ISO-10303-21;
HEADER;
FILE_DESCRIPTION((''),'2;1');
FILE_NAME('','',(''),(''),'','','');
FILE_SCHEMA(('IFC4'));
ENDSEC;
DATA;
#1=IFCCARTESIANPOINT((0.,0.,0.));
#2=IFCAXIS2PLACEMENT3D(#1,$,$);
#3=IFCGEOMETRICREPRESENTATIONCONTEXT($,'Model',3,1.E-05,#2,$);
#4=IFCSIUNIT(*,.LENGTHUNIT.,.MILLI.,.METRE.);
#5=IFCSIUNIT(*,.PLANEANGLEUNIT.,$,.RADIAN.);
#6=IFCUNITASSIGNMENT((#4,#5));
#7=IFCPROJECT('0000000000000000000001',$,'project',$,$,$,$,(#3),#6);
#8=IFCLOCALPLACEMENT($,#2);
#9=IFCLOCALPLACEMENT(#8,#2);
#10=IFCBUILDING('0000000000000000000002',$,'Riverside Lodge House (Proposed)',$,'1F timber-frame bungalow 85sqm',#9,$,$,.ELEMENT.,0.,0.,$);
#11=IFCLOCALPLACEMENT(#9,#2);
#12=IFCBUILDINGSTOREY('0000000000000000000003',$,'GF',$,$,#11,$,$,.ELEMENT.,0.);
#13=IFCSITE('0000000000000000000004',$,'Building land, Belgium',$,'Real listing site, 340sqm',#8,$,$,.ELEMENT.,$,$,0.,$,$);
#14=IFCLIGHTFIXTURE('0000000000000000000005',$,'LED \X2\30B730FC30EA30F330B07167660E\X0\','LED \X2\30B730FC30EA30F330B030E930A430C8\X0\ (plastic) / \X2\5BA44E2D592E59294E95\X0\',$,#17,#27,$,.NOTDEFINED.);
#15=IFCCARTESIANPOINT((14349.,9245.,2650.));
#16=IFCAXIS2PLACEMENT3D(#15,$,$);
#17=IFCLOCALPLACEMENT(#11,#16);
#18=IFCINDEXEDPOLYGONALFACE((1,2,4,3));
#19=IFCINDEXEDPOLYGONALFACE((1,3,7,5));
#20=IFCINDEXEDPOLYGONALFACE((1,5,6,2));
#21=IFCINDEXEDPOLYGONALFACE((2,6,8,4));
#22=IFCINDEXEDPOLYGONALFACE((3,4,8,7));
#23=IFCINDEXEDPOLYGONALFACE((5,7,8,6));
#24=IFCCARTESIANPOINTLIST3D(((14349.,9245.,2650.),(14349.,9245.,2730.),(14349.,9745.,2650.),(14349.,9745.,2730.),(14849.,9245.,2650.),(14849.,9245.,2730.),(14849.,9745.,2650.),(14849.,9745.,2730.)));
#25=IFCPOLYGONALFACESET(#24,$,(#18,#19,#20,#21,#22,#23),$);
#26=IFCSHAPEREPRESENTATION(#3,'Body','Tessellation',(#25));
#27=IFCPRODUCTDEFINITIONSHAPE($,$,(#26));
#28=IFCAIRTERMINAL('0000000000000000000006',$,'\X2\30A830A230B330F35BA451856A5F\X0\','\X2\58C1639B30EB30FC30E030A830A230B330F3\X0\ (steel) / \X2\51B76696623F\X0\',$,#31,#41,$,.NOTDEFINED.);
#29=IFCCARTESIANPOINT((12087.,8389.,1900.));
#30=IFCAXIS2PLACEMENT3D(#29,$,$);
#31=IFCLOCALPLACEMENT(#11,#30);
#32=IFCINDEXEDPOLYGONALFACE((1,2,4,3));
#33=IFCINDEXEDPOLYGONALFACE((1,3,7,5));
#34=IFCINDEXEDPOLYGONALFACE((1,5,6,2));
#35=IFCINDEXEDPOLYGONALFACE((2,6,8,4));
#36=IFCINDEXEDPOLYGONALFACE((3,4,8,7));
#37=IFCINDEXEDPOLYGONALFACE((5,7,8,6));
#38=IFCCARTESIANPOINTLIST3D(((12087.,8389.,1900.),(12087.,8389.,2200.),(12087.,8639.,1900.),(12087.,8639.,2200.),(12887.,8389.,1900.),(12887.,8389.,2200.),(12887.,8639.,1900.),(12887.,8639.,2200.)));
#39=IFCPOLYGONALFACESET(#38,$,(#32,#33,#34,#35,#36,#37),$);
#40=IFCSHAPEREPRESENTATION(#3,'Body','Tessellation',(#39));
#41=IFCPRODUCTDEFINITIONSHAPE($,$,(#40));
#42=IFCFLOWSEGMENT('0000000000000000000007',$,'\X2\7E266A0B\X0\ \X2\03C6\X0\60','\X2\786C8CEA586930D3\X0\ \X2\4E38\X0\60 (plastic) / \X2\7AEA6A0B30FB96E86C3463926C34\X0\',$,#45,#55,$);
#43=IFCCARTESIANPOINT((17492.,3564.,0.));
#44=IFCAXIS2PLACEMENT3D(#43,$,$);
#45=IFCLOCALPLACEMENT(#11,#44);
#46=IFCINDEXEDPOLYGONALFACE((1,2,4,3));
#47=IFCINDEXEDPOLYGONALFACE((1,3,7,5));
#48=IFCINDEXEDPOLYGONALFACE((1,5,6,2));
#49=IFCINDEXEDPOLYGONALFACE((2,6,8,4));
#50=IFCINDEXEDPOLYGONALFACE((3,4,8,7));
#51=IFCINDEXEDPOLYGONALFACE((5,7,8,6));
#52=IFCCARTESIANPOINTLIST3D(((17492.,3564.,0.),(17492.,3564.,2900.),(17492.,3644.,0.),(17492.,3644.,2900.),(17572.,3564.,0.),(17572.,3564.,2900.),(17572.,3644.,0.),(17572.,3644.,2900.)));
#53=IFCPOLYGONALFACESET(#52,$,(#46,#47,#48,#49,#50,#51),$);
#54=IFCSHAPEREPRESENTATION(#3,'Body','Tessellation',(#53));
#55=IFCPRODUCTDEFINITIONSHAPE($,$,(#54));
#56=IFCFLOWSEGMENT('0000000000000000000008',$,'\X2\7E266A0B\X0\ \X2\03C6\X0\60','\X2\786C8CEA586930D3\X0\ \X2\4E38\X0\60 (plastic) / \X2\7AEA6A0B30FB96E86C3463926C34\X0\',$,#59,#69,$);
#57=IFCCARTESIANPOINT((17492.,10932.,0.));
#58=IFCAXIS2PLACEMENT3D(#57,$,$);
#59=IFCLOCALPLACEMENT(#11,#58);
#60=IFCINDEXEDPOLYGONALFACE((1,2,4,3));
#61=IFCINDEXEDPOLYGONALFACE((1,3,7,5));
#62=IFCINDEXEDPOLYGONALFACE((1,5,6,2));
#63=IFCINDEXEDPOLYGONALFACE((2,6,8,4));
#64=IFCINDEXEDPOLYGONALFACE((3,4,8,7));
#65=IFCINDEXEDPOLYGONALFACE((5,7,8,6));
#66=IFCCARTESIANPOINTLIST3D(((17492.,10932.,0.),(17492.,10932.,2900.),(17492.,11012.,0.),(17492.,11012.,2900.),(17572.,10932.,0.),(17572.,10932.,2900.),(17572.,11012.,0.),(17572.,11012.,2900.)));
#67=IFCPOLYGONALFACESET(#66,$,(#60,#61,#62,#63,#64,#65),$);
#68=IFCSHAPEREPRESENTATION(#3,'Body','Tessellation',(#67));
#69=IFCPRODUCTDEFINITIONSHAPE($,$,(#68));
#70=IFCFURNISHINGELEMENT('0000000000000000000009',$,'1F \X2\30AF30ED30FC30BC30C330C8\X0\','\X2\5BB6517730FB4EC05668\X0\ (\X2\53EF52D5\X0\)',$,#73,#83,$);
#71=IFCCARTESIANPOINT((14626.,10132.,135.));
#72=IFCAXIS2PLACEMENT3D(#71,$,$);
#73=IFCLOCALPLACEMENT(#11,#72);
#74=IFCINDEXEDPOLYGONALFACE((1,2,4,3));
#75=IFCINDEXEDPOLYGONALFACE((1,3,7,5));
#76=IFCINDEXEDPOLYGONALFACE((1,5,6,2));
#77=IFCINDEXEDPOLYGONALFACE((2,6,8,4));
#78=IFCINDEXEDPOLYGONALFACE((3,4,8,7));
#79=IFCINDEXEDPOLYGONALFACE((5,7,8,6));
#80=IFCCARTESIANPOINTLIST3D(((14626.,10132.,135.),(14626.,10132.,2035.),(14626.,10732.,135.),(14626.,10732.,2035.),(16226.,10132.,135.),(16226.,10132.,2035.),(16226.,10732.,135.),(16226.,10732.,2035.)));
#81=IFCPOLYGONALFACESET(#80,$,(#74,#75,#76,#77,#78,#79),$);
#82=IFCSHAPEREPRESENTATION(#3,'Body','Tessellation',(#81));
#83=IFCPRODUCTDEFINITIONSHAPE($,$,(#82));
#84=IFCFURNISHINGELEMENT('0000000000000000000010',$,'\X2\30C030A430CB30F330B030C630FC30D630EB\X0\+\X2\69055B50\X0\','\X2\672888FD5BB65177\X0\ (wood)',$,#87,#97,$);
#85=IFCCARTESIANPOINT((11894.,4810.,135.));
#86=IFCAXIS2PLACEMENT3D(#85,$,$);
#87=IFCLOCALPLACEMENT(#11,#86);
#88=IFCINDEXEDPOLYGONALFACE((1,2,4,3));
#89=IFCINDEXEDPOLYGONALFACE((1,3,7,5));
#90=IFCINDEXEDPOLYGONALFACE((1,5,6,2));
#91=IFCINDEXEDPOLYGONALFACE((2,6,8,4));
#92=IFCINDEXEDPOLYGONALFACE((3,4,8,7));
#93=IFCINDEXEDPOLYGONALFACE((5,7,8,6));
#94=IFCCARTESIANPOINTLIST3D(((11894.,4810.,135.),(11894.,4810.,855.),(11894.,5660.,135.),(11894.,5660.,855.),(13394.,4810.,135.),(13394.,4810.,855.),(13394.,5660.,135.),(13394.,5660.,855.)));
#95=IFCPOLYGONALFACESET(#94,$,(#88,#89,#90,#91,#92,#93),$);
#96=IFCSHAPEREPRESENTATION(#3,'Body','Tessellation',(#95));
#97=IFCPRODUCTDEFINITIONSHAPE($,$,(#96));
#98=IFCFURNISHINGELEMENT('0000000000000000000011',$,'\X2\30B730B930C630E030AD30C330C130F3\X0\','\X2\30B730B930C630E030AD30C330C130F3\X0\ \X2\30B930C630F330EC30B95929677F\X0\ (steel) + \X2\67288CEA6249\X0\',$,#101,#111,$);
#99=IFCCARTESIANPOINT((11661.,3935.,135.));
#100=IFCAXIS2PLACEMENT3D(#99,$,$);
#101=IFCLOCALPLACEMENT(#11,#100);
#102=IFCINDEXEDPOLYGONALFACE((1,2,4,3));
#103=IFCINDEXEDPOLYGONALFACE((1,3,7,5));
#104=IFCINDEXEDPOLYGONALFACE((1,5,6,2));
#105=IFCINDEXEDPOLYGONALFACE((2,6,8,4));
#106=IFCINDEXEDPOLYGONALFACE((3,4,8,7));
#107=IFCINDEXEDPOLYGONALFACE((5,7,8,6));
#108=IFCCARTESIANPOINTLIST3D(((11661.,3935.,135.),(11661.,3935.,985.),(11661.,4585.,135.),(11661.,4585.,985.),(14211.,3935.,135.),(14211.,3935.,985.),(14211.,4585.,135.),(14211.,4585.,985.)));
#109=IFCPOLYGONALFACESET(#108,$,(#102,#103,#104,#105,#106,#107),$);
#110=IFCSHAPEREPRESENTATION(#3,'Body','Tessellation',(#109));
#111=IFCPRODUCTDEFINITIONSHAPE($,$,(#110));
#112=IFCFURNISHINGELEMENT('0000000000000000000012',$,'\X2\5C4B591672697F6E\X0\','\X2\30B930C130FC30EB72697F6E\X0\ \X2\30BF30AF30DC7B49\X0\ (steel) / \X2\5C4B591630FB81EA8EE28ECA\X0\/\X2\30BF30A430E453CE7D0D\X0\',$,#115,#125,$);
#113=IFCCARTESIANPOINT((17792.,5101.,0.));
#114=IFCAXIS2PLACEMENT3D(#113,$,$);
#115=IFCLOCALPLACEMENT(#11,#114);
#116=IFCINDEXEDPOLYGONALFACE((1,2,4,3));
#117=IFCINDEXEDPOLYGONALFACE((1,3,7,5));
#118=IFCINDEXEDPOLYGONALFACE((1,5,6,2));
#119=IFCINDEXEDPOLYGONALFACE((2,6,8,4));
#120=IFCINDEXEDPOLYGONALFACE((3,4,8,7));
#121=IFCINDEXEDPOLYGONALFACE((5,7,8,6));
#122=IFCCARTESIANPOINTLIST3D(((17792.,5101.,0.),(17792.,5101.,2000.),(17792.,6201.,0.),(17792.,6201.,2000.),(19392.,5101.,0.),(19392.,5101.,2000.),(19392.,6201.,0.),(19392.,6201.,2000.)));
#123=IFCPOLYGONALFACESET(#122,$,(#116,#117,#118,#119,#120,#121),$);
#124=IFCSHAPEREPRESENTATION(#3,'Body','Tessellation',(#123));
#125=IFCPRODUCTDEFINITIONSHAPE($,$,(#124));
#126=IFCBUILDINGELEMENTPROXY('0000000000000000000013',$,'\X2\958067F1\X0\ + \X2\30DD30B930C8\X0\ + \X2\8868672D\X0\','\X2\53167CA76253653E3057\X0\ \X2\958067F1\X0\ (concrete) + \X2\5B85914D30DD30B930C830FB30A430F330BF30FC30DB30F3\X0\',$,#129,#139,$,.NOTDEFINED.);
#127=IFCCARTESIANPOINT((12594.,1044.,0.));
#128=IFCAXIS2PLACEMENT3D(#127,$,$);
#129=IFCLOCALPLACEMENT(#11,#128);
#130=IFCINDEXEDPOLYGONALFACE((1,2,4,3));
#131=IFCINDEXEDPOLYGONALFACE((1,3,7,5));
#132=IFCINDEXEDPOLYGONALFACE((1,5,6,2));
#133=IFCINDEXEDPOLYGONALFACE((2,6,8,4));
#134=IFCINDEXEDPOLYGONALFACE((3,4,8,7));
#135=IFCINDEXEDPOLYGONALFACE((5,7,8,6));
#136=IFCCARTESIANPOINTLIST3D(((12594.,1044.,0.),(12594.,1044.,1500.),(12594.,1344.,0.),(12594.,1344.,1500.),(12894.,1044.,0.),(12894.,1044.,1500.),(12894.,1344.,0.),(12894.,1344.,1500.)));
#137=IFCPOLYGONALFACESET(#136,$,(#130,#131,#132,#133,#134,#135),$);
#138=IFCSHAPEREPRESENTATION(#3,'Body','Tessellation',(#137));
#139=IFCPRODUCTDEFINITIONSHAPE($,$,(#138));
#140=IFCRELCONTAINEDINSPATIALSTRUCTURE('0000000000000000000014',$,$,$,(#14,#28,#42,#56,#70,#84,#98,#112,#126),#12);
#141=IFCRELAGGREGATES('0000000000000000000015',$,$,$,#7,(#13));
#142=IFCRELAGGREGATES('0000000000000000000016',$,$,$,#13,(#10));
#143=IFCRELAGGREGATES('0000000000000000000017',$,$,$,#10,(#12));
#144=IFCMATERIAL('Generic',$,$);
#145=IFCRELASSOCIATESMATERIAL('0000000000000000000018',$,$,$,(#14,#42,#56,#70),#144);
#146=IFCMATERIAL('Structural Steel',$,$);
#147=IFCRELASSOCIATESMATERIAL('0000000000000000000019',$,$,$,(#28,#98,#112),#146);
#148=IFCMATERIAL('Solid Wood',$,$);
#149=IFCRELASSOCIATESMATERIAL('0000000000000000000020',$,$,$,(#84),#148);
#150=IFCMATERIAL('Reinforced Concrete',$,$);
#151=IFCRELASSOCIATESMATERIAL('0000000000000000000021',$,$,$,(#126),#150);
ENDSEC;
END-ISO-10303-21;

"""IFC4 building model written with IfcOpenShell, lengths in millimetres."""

from ifc_helpers import new_model, si_unit, frame, frame_2d, origin, place, context, project, spatial, rectangle, extrude, material, element, save


model = new_model("IFC4")

# Units and contexts
model_context = context("Model", 3, precision=1e-05, world=origin())
ifc_project = project(units=[si_unit("LENGTHUNIT", "METRE", prefix="MILLI"), si_unit("PLANEANGLEUNIT", "RADIAN")], contexts=[model_context])

# Site, building, storey
site_placement = place(None, origin())
site = spatial("IfcSite", under=ifc_project, at=site_placement, Name="Building land, Belgium", ObjectType="Real listing site, 340sqm", CompositionType="ELEMENT", RefElevation=0.0)
building_placement = place(site_placement, origin())
building = spatial("IfcBuilding", under=site, at=building_placement, Name="Riverside Lodge House (Proposed)", ObjectType="1F timber-frame bungalow 85sqm", CompositionType="ELEMENT", ElevationOfRefHeight=0.0, ElevationOfTerrain=0.0)
storey_placement = place(building_placement, origin())
storey = spatial("IfcBuildingStorey", under=building, at=storey_placement, Name="GF", CompositionType="ELEMENT", Elevation=0.0)

# Shared definitions
ifc_material_1 = material(Name="Solid Wood")

# Shared definitions
ifc_material_2 = material(Name="Reinforced Concrete")

# Shared definitions
ifc_material_3 = material(Name="Generic")

# Shared definitions
ifc_material_4 = material(Name="Structural Steel")

# Light fixture
light_fixture_1_placement = place(storey_placement, frame((14349.0, 9245.0, 2650.0)))
element("IfcLightFixture", 1, at=light_fixture_1_placement, inside=storey, material=ifc_material_3, Name="LED シーリング照明", Description="LED シーリングライト (plastic) / 室中央天井", PredefinedType="NOTDEFINED", context=model_context, shape_type="SweptSolid", body=[
    extrude(rectangle(XDim=500.0, YDim=500.0, at=frame_2d((250.0, 250.0))), frame((14349.0, 9245.0, 2650.0)), (0.0, 0.0, 1.0), 80.0),
])

# Air terminal
air_terminal_placement = place(storey_placement, frame((12087.0, 8389.0, 1900.0)))
element("IfcAirTerminal", 2, at=air_terminal_placement, inside=storey, material=ifc_material_4, Name="エアコン室内機", Description="壁掛ルームエアコン (steel) / 冷暖房", PredefinedType="NOTDEFINED", context=model_context, shape_type="SweptSolid", body=[
    extrude(rectangle(XDim=800.0, YDim=250.0, at=frame_2d((400.0, 125.0))), frame((12087.0, 8389.0, 1900.0)), (0.0, 0.0, 1.0), 300.0),
])

# Flow segments
flow_segment_1_placement = place(storey_placement, frame((17492.0, 3564.0, 0.0)))
element("IfcFlowSegment", 3, at=flow_segment_1_placement, inside=storey, material=ifc_material_3, Name="縦樋 φ60", Description="硬質塩ビ 丸60 (plastic) / 竪樋・雨水排水", context=model_context, shape_type="SweptSolid", body=[
    extrude(rectangle(XDim=80.0, YDim=80.0, at=frame_2d((40.0, 40.0))), frame((17492.0, 3564.0, 0.0)), (0.0, 0.0, 1.0), 2900.0),
])
flow_segment_2_placement = place(storey_placement, frame((17492.0, 10932.0, 0.0)))
element("IfcFlowSegment", 4, at=flow_segment_2_placement, inside=storey, material=ifc_material_3, Name="縦樋 φ60", Description="硬質塩ビ 丸60 (plastic) / 竪樋・雨水排水", context=model_context, shape_type="SweptSolid", body=[
    extrude(rectangle(XDim=80.0, YDim=80.0, at=frame_2d((40.0, 40.0))), frame((17492.0, 10932.0, 0.0)), (0.0, 0.0, 1.0), 2900.0),
])

# Furnishing elements
furnishing_1_placement = place(storey_placement, frame((14626.0, 10132.0, 135.0)))
element("IfcFurnishingElement", 5, at=furnishing_1_placement, inside=storey, material=ifc_material_3, Name="1F クローゼット", Description="家具・什器 (可動)", context=model_context, shape_type="SweptSolid", body=[
    extrude(rectangle(XDim=1600.0, YDim=600.0, at=frame_2d((800.0, 300.0))), frame((14626.0, 10132.0, 135.0)), (0.0, 0.0, 1.0), 1900.0),
])
furnishing_2_placement = place(storey_placement, frame((11894.0, 4810.0, 135.0)))
element("IfcFurnishingElement", 6, at=furnishing_2_placement, inside=storey, material=ifc_material_1, Name="ダイニングテーブル+椅子", Description="木製家具 (wood)", context=model_context, shape_type="SweptSolid", body=[
    extrude(rectangle(XDim=1500.0, YDim=850.0, at=frame_2d((750.0, 425.0))), frame((11894.0, 4810.0, 135.0)), (0.0, 0.0, 1.0), 720.0),
])
furnishing_3_placement = place(storey_placement, frame((11661.0, 3935.0, 135.0)))
element("IfcFurnishingElement", 7, at=furnishing_3_placement, inside=storey, material=ifc_material_4, Name="システムキッチン", Description="システムキッチン ステンレス天板 (steel) + 木質扉", context=model_context, shape_type="SweptSolid", body=[
    extrude(rectangle(XDim=2550.0, YDim=650.0, at=frame_2d((1275.0, 325.0))), frame((11661.0, 3935.0, 135.0)), (0.0, 0.0, 1.0), 850.0),
])
furnishing_4_placement = place(storey_placement, frame((17792.0, 5101.0, 0.0)))
element("IfcFurnishingElement", 8, at=furnishing_4_placement, inside=storey, material=ifc_material_4, Name="屋外物置", Description="スチール物置 タクボ等 (steel) / 屋外・自転車/タイヤ収納", context=model_context, shape_type="SweptSolid", body=[
    extrude(rectangle(XDim=1600.0, YDim=1100.0, at=frame_2d((800.0, 550.0))), frame((17792.0, 5101.0, 0.0)), (0.0, 0.0, 1.0), 2000.0),
])

# Building element proxy
proxy_placement = place(storey_placement, frame((12594.0, 1044.0, 0.0)))
element("IfcBuildingElementProxy", 9, at=proxy_placement, inside=storey, material=ifc_material_2, Name="門柱 + ポスト + 表札", Description="化粧打放し 門柱 (concrete) + 宅配ポスト・インターホン", PredefinedType="NOTDEFINED", context=model_context, shape_type="SweptSolid", body=[
    extrude(rectangle(XDim=300.0, YDim=300.0, at=frame_2d((150.0, 150.0))), frame((12594.0, 1044.0, 0.0)), (0.0, 0.0, 1.0), 1500.0),
])

save(model, "model.ifc")
